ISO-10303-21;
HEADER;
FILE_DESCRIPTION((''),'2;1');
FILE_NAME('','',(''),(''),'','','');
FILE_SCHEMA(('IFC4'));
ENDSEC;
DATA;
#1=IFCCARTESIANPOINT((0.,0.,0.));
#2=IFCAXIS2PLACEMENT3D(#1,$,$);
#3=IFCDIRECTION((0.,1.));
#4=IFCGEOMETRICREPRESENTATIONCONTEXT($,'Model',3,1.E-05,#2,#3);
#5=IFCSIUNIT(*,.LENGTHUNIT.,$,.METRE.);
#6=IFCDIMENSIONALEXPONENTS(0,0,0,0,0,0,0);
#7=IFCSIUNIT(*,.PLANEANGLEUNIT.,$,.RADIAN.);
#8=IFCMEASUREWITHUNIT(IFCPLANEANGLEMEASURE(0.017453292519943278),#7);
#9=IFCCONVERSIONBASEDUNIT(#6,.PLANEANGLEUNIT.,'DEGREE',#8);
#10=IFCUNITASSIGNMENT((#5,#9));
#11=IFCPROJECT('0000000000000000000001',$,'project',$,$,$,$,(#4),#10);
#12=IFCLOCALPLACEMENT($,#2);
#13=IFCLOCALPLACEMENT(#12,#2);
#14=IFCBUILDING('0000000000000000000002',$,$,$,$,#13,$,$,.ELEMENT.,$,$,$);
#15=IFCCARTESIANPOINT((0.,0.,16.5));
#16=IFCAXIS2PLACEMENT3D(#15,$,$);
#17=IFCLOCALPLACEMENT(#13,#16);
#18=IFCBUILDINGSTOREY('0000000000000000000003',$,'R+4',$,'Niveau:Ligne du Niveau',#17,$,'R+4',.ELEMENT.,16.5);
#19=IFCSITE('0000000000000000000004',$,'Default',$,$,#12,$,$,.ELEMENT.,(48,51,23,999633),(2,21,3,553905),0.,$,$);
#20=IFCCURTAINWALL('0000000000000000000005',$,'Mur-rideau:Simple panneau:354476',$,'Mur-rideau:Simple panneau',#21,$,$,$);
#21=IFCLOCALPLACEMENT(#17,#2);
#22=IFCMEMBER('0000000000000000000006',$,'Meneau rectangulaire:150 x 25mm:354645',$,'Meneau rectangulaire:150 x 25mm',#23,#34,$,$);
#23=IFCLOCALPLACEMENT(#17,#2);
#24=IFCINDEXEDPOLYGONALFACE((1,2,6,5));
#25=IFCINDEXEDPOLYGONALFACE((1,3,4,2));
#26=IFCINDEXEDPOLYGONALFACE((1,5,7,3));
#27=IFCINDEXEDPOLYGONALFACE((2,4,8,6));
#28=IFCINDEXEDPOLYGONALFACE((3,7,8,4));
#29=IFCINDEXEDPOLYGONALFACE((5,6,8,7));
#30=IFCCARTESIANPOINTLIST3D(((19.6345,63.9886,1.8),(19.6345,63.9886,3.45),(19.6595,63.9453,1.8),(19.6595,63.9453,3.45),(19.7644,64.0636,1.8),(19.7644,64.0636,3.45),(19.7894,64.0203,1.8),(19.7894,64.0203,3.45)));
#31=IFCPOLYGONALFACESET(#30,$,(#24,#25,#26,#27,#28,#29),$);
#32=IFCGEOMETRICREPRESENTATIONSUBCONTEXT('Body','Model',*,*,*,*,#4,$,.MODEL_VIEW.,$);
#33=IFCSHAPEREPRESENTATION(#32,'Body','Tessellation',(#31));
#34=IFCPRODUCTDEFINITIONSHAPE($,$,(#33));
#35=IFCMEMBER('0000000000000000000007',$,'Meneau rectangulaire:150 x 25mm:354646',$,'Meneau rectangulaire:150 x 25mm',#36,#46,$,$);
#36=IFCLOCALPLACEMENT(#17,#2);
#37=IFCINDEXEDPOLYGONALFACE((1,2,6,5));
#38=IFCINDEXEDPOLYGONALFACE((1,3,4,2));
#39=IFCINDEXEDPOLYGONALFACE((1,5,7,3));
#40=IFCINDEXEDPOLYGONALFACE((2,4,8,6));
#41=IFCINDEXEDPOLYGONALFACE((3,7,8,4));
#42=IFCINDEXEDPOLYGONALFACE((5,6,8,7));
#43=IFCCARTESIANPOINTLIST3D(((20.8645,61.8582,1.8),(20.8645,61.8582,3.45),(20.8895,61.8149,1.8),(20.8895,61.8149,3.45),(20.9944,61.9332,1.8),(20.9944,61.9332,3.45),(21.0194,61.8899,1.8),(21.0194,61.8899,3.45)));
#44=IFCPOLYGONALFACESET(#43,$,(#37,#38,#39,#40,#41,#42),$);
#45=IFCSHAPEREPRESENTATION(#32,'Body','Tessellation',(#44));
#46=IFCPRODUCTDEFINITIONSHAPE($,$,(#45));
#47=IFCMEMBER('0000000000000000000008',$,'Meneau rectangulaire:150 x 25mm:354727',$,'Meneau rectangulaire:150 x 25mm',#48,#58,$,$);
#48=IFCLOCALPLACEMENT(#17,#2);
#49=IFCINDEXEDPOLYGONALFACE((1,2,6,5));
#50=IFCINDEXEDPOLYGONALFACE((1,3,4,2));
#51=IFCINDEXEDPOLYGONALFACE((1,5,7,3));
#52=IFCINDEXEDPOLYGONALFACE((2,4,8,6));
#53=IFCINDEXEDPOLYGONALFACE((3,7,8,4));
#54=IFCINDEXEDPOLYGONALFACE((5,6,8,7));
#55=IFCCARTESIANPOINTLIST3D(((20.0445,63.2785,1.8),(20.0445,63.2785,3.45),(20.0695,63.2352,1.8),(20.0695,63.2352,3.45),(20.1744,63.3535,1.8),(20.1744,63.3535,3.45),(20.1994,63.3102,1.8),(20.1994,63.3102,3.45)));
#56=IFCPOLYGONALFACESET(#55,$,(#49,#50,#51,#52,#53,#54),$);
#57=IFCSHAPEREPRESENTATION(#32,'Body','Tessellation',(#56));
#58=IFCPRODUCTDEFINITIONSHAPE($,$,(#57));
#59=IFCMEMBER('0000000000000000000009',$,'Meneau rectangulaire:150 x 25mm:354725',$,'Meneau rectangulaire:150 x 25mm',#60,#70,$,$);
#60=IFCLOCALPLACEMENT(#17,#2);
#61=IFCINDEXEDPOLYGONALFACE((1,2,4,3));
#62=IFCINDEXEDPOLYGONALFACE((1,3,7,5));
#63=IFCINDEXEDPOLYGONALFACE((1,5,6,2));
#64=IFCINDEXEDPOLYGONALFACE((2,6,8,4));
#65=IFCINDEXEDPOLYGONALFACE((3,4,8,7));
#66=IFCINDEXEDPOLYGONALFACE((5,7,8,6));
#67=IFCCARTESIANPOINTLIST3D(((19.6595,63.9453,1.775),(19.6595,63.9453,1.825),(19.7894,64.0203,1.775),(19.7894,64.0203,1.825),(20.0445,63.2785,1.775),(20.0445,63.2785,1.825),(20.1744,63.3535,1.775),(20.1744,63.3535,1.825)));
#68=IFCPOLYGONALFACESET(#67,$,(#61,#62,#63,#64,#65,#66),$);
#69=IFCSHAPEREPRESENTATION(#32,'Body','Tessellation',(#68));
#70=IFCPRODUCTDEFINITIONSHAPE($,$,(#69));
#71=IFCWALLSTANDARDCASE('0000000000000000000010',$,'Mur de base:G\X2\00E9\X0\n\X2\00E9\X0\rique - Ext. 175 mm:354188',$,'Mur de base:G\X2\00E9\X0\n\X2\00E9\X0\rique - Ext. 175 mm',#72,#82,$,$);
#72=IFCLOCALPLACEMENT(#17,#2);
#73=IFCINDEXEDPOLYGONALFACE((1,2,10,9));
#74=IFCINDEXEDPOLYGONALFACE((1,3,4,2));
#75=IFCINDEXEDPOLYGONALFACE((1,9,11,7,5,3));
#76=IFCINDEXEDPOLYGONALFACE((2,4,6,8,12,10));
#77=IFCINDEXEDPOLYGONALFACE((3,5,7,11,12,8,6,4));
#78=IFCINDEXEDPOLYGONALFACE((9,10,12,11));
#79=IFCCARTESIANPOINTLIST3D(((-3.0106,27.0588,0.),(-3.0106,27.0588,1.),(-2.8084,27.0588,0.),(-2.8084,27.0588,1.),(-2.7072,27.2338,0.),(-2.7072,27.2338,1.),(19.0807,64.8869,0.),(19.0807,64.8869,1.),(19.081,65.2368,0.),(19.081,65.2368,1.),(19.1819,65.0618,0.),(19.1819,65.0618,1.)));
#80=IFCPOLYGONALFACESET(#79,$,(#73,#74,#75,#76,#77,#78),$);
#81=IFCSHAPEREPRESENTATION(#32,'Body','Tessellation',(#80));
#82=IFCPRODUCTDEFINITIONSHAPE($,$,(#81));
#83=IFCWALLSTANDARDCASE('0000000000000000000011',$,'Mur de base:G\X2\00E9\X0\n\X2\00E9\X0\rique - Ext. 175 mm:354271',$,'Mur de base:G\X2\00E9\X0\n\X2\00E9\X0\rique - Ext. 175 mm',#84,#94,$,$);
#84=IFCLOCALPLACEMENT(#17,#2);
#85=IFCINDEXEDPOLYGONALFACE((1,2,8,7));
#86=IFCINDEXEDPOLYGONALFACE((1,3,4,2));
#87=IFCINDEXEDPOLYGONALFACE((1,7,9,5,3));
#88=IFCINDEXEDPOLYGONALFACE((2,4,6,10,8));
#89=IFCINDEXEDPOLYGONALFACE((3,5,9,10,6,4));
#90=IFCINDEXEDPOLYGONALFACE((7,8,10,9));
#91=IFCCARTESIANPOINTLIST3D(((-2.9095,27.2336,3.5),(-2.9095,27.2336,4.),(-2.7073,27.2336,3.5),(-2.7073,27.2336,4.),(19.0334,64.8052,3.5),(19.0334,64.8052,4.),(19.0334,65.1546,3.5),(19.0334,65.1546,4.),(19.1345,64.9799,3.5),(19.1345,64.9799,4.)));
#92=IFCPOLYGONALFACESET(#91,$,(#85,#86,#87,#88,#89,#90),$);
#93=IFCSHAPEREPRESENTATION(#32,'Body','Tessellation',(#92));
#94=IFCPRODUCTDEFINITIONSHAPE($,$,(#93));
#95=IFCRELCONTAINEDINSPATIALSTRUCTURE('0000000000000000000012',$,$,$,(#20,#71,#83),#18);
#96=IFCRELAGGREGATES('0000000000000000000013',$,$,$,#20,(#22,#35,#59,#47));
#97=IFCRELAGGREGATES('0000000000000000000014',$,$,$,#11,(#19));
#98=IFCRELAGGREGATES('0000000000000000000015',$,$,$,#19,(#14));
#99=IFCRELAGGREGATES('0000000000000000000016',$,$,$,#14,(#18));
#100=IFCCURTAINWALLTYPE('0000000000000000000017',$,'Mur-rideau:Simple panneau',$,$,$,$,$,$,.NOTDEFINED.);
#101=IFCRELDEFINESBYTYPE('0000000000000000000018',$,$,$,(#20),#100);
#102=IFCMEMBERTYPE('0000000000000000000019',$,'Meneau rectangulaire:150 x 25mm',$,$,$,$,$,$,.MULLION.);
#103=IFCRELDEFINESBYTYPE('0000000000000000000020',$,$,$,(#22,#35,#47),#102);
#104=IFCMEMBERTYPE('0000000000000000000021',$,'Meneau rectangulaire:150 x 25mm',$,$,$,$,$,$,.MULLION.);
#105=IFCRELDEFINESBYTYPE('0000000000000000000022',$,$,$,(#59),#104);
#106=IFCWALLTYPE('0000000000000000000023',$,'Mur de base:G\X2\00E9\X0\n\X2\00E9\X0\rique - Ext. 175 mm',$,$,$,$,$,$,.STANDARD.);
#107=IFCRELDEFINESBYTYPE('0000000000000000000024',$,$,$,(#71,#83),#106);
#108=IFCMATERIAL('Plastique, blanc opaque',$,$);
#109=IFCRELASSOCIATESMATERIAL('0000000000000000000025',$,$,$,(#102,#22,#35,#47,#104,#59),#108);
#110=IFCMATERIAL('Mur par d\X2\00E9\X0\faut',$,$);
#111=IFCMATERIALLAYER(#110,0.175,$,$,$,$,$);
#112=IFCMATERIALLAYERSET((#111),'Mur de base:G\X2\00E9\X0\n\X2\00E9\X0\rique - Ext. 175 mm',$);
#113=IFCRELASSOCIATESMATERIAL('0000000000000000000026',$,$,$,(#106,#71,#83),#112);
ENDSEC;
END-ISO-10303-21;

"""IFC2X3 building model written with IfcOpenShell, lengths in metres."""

from ifc_helpers import new_model, entity, si_unit, converted_unit, direction, frame, origin, origin_2d_with_axis, place, context, subcontext, project, spatial, polyline, rectangle, outline, extrude, source, transform, mapped, material, layer, layer_set, layer_usage, type_object, type_shapes, element, aggregate, save


model = new_model("IFC2X3")

# Units and contexts
model_context = context("Model", 3, precision=1e-05, world=origin(), true_north=direction((0.0, 1.0)))
body_context = subcontext(model_context, "Body", "Model", "MODEL_VIEW")
ifc_project = project(units=[si_unit("LENGTHUNIT", "METRE"), converted_unit("PLANEANGLEUNIT", "DEGREE", entity("IfcPlaneAngleMeasure", 0.017453292519943278), si_unit("PLANEANGLEUNIT", "RADIAN"), dimensions=[0, 0, 0, 0, 0, 0, 0])], contexts=[model_context])

# Site, building, storey
site_placement = place(None, origin())
site = spatial("IfcSite", under=ifc_project, at=site_placement, Name="Default", CompositionType="ELEMENT", RefLatitude=(48, 51, 23, 999633), RefLongitude=(2, 21, 3, 553905), RefElevation=0.0)
building_placement = place(site_placement, origin())
building = spatial("IfcBuilding", under=site, at=building_placement, CompositionType="ELEMENT")
storey_placement = place(building_placement, frame((0.0, 0.0, 16.5)))
storey = spatial("IfcBuildingStorey", under=building, at=storey_placement, Name="R+4", ObjectType="Niveau:Ligne du Niveau", LongName="R+4", CompositionType="ELEMENT", Elevation=16.5)

# Shared definitions
curtain_wall_type = type_object("IfcCurtainWallType", Name="Mur-rideau:Simple panneau", PredefinedType="NOTDEFINED")
ifc_material_1 = material(Name="Plastique, blanc opaque")

# Curtain wall, members
curtain_wall_1_placement = place(storey_placement, frame((0.0, 0.0, -16.5)))
curtain_wall_1 = element("IfcCurtainWall", 1, at=curtain_wall_1_placement, inside=storey, type_object=curtain_wall_type, Name="Mur-rideau:Simple panneau:354476", ObjectType="Mur-rideau:Simple panneau")
member_type_1 = type_object("IfcMemberType", Name="Meneau rectangulaire:150 x 25mm", PredefinedType="MULLION", material=ifc_material_1)
shared_shape_1 = source(origin(), body_context, "Body", "SweptSolid", [
    extrude(rectangle(XDim=0.05, YDim=0.15, at=origin_2d_with_axis()), frame((0.0, 0.0, -1.65), z_axis=(0.0, 0.0, 1.0), x_axis=(-1.0, 0.0, 0.0)), (0.0, 0.0, 1.0), 1.65),
])
type_shapes(member_type_1, [shared_shape_1])
member_1_placement = place(curtain_wall_1_placement, frame((19.712, 64.0045, 18.3), z_axis=(0.0, 0.0, -1.0), x_axis=(0.5, -0.866025, 0.0)))
member_1 = element("IfcMember", 2, at=member_1_placement, type_object=member_type_1, material=ifc_material_1, Name="Meneau rectangulaire:150 x 25mm:354645", ObjectType="Meneau rectangulaire:150 x 25mm", context=body_context, shape_type="MappedRepresentation", body=[
    mapped(shared_shape_1, transform((0.0, 0.0, 0.0), scale=1.0)),
])
member_2_placement = place(curtain_wall_1_placement, frame((20.942, 61.874, 18.3), z_axis=(0.0, 0.0, -1.0), x_axis=(0.5, -0.866025, 0.0)))
member_2 = element("IfcMember", 3, at=member_2_placement, type_object=member_type_1, material=ifc_material_1, Name="Meneau rectangulaire:150 x 25mm:354646", ObjectType="Meneau rectangulaire:150 x 25mm", context=body_context, shape_type="MappedRepresentation", body=[
    mapped(shared_shape_1, transform((0.0, 0.0, 0.0), scale=1.0)),
])
member_3_placement = place(curtain_wall_1_placement, frame((20.122, 63.2943, 18.3), z_axis=(0.0, 0.0, -1.0), x_axis=(0.5, -0.866025, 0.0)))
member_3 = element("IfcMember", 4, at=member_3_placement, type_object=member_type_1, material=ifc_material_1, Name="Meneau rectangulaire:150 x 25mm:354727", ObjectType="Meneau rectangulaire:150 x 25mm", context=body_context, shape_type="MappedRepresentation", body=[
    mapped(shared_shape_1, transform((0.0, 0.0, 0.0), scale=1.0)),
])
member_type_2 = type_object("IfcMemberType", Name="Meneau rectangulaire:150 x 25mm", PredefinedType="MULLION", material=ifc_material_1)
shared_shape_2 = source(origin(), body_context, "Body", "SweptSolid", [
    extrude(rectangle(XDim=0.05, YDim=0.15, at=origin_2d_with_axis()), frame((0.0, 0.0, -0.77), z_axis=(0.0, 0.0, 1.0), x_axis=(-1.0, 0.0, 0.0)), (0.0, 0.0, 1.0), 0.77),
])
type_shapes(member_type_2, [shared_shape_2])
member_4_placement = place(curtain_wall_1_placement, frame((20.1095, 63.316, 18.3), z_axis=(0.5, -0.866025, 0.0), x_axis=(0.0, 0.0, 1.0)))
member_4 = element("IfcMember", 5, at=member_4_placement, type_object=member_type_2, material=ifc_material_1, Name="Meneau rectangulaire:150 x 25mm:354725", ObjectType="Meneau rectangulaire:150 x 25mm", context=body_context, shape_type="MappedRepresentation", body=[
    mapped(shared_shape_2, transform((0.0, 0.0, 0.0), scale=1.0)),
])
aggregate(curtain_wall_1, [member_1, member_2, member_4, member_3])

# Walls
ifc_material_2 = material(Name="Mur par défaut")
ifc_layer_1 = layer(ifc_material_2, 0.175)
ifc_layer_set_1 = layer_set([ifc_layer_1], Name="Mur de base:Générique - Ext. 175 mm")
ifc_layer_usage_1 = layer_usage(ifc_layer_set_1, "AXIS2", "NEGATIVE", 0.0875)
wall_type = type_object("IfcWallType", Name="Mur de base:Générique - Ext. 175 mm", PredefinedType="STANDARD", material=ifc_layer_set_1)
wall_1_placement = place(storey_placement, frame((19.1567, 65.1929, 0.0), z_axis=(0.0, 0.0, 1.0), x_axis=(-0.500842, -0.865539, 0.0)))
element("IfcWallStandardCase", 6, at=wall_1_placement, inside=storey, type_object=wall_type, material=ifc_layer_usage_1, Name="Mur de base:Générique - Ext. 175 mm:354188", ObjectType="Mur de base:Générique - Ext. 175 mm", context=body_context, shape_type="SweptSolid", body=[
    extrude(outline(polyline([(44.1089, -0.0875), (44.0076, 0.0875), (43.8054, 0.0875), (0.3029, 0.0875), (0.1009, 0.0875), (0.0, -0.0875), (44.1089, -0.0875)])), origin(), (0.0, 0.0, 1.0), 1.0),
])
ifc_layer_usage_2 = layer_usage(ifc_layer_set_1, "AXIS2", "NEGATIVE", 0.0875)
wall_2_placement = place(storey_placement, frame((19.1092, 65.1108, 3.5), z_axis=(0.0, 0.0, 1.0), x_axis=(-0.500842, -0.865539, 0.0)))
element("IfcWallStandardCase", 7, at=wall_2_placement, inside=storey, type_object=wall_type, material=ifc_layer_usage_2, Name="Mur de base:Générique - Ext. 175 mm:354271", ObjectType="Mur de base:Générique - Ext. 175 mm", context=body_context, shape_type="SweptSolid", body=[
    extrude(outline(polyline([(43.8121, -0.0875), (43.7108, 0.0875), (0.3024, 0.0875), (0.1006, 0.0875), (0.0, -0.0875), (43.8121, -0.0875)])), origin(), (0.0, 0.0, 1.0), 0.5),
])

save(model, "model.ifc")
